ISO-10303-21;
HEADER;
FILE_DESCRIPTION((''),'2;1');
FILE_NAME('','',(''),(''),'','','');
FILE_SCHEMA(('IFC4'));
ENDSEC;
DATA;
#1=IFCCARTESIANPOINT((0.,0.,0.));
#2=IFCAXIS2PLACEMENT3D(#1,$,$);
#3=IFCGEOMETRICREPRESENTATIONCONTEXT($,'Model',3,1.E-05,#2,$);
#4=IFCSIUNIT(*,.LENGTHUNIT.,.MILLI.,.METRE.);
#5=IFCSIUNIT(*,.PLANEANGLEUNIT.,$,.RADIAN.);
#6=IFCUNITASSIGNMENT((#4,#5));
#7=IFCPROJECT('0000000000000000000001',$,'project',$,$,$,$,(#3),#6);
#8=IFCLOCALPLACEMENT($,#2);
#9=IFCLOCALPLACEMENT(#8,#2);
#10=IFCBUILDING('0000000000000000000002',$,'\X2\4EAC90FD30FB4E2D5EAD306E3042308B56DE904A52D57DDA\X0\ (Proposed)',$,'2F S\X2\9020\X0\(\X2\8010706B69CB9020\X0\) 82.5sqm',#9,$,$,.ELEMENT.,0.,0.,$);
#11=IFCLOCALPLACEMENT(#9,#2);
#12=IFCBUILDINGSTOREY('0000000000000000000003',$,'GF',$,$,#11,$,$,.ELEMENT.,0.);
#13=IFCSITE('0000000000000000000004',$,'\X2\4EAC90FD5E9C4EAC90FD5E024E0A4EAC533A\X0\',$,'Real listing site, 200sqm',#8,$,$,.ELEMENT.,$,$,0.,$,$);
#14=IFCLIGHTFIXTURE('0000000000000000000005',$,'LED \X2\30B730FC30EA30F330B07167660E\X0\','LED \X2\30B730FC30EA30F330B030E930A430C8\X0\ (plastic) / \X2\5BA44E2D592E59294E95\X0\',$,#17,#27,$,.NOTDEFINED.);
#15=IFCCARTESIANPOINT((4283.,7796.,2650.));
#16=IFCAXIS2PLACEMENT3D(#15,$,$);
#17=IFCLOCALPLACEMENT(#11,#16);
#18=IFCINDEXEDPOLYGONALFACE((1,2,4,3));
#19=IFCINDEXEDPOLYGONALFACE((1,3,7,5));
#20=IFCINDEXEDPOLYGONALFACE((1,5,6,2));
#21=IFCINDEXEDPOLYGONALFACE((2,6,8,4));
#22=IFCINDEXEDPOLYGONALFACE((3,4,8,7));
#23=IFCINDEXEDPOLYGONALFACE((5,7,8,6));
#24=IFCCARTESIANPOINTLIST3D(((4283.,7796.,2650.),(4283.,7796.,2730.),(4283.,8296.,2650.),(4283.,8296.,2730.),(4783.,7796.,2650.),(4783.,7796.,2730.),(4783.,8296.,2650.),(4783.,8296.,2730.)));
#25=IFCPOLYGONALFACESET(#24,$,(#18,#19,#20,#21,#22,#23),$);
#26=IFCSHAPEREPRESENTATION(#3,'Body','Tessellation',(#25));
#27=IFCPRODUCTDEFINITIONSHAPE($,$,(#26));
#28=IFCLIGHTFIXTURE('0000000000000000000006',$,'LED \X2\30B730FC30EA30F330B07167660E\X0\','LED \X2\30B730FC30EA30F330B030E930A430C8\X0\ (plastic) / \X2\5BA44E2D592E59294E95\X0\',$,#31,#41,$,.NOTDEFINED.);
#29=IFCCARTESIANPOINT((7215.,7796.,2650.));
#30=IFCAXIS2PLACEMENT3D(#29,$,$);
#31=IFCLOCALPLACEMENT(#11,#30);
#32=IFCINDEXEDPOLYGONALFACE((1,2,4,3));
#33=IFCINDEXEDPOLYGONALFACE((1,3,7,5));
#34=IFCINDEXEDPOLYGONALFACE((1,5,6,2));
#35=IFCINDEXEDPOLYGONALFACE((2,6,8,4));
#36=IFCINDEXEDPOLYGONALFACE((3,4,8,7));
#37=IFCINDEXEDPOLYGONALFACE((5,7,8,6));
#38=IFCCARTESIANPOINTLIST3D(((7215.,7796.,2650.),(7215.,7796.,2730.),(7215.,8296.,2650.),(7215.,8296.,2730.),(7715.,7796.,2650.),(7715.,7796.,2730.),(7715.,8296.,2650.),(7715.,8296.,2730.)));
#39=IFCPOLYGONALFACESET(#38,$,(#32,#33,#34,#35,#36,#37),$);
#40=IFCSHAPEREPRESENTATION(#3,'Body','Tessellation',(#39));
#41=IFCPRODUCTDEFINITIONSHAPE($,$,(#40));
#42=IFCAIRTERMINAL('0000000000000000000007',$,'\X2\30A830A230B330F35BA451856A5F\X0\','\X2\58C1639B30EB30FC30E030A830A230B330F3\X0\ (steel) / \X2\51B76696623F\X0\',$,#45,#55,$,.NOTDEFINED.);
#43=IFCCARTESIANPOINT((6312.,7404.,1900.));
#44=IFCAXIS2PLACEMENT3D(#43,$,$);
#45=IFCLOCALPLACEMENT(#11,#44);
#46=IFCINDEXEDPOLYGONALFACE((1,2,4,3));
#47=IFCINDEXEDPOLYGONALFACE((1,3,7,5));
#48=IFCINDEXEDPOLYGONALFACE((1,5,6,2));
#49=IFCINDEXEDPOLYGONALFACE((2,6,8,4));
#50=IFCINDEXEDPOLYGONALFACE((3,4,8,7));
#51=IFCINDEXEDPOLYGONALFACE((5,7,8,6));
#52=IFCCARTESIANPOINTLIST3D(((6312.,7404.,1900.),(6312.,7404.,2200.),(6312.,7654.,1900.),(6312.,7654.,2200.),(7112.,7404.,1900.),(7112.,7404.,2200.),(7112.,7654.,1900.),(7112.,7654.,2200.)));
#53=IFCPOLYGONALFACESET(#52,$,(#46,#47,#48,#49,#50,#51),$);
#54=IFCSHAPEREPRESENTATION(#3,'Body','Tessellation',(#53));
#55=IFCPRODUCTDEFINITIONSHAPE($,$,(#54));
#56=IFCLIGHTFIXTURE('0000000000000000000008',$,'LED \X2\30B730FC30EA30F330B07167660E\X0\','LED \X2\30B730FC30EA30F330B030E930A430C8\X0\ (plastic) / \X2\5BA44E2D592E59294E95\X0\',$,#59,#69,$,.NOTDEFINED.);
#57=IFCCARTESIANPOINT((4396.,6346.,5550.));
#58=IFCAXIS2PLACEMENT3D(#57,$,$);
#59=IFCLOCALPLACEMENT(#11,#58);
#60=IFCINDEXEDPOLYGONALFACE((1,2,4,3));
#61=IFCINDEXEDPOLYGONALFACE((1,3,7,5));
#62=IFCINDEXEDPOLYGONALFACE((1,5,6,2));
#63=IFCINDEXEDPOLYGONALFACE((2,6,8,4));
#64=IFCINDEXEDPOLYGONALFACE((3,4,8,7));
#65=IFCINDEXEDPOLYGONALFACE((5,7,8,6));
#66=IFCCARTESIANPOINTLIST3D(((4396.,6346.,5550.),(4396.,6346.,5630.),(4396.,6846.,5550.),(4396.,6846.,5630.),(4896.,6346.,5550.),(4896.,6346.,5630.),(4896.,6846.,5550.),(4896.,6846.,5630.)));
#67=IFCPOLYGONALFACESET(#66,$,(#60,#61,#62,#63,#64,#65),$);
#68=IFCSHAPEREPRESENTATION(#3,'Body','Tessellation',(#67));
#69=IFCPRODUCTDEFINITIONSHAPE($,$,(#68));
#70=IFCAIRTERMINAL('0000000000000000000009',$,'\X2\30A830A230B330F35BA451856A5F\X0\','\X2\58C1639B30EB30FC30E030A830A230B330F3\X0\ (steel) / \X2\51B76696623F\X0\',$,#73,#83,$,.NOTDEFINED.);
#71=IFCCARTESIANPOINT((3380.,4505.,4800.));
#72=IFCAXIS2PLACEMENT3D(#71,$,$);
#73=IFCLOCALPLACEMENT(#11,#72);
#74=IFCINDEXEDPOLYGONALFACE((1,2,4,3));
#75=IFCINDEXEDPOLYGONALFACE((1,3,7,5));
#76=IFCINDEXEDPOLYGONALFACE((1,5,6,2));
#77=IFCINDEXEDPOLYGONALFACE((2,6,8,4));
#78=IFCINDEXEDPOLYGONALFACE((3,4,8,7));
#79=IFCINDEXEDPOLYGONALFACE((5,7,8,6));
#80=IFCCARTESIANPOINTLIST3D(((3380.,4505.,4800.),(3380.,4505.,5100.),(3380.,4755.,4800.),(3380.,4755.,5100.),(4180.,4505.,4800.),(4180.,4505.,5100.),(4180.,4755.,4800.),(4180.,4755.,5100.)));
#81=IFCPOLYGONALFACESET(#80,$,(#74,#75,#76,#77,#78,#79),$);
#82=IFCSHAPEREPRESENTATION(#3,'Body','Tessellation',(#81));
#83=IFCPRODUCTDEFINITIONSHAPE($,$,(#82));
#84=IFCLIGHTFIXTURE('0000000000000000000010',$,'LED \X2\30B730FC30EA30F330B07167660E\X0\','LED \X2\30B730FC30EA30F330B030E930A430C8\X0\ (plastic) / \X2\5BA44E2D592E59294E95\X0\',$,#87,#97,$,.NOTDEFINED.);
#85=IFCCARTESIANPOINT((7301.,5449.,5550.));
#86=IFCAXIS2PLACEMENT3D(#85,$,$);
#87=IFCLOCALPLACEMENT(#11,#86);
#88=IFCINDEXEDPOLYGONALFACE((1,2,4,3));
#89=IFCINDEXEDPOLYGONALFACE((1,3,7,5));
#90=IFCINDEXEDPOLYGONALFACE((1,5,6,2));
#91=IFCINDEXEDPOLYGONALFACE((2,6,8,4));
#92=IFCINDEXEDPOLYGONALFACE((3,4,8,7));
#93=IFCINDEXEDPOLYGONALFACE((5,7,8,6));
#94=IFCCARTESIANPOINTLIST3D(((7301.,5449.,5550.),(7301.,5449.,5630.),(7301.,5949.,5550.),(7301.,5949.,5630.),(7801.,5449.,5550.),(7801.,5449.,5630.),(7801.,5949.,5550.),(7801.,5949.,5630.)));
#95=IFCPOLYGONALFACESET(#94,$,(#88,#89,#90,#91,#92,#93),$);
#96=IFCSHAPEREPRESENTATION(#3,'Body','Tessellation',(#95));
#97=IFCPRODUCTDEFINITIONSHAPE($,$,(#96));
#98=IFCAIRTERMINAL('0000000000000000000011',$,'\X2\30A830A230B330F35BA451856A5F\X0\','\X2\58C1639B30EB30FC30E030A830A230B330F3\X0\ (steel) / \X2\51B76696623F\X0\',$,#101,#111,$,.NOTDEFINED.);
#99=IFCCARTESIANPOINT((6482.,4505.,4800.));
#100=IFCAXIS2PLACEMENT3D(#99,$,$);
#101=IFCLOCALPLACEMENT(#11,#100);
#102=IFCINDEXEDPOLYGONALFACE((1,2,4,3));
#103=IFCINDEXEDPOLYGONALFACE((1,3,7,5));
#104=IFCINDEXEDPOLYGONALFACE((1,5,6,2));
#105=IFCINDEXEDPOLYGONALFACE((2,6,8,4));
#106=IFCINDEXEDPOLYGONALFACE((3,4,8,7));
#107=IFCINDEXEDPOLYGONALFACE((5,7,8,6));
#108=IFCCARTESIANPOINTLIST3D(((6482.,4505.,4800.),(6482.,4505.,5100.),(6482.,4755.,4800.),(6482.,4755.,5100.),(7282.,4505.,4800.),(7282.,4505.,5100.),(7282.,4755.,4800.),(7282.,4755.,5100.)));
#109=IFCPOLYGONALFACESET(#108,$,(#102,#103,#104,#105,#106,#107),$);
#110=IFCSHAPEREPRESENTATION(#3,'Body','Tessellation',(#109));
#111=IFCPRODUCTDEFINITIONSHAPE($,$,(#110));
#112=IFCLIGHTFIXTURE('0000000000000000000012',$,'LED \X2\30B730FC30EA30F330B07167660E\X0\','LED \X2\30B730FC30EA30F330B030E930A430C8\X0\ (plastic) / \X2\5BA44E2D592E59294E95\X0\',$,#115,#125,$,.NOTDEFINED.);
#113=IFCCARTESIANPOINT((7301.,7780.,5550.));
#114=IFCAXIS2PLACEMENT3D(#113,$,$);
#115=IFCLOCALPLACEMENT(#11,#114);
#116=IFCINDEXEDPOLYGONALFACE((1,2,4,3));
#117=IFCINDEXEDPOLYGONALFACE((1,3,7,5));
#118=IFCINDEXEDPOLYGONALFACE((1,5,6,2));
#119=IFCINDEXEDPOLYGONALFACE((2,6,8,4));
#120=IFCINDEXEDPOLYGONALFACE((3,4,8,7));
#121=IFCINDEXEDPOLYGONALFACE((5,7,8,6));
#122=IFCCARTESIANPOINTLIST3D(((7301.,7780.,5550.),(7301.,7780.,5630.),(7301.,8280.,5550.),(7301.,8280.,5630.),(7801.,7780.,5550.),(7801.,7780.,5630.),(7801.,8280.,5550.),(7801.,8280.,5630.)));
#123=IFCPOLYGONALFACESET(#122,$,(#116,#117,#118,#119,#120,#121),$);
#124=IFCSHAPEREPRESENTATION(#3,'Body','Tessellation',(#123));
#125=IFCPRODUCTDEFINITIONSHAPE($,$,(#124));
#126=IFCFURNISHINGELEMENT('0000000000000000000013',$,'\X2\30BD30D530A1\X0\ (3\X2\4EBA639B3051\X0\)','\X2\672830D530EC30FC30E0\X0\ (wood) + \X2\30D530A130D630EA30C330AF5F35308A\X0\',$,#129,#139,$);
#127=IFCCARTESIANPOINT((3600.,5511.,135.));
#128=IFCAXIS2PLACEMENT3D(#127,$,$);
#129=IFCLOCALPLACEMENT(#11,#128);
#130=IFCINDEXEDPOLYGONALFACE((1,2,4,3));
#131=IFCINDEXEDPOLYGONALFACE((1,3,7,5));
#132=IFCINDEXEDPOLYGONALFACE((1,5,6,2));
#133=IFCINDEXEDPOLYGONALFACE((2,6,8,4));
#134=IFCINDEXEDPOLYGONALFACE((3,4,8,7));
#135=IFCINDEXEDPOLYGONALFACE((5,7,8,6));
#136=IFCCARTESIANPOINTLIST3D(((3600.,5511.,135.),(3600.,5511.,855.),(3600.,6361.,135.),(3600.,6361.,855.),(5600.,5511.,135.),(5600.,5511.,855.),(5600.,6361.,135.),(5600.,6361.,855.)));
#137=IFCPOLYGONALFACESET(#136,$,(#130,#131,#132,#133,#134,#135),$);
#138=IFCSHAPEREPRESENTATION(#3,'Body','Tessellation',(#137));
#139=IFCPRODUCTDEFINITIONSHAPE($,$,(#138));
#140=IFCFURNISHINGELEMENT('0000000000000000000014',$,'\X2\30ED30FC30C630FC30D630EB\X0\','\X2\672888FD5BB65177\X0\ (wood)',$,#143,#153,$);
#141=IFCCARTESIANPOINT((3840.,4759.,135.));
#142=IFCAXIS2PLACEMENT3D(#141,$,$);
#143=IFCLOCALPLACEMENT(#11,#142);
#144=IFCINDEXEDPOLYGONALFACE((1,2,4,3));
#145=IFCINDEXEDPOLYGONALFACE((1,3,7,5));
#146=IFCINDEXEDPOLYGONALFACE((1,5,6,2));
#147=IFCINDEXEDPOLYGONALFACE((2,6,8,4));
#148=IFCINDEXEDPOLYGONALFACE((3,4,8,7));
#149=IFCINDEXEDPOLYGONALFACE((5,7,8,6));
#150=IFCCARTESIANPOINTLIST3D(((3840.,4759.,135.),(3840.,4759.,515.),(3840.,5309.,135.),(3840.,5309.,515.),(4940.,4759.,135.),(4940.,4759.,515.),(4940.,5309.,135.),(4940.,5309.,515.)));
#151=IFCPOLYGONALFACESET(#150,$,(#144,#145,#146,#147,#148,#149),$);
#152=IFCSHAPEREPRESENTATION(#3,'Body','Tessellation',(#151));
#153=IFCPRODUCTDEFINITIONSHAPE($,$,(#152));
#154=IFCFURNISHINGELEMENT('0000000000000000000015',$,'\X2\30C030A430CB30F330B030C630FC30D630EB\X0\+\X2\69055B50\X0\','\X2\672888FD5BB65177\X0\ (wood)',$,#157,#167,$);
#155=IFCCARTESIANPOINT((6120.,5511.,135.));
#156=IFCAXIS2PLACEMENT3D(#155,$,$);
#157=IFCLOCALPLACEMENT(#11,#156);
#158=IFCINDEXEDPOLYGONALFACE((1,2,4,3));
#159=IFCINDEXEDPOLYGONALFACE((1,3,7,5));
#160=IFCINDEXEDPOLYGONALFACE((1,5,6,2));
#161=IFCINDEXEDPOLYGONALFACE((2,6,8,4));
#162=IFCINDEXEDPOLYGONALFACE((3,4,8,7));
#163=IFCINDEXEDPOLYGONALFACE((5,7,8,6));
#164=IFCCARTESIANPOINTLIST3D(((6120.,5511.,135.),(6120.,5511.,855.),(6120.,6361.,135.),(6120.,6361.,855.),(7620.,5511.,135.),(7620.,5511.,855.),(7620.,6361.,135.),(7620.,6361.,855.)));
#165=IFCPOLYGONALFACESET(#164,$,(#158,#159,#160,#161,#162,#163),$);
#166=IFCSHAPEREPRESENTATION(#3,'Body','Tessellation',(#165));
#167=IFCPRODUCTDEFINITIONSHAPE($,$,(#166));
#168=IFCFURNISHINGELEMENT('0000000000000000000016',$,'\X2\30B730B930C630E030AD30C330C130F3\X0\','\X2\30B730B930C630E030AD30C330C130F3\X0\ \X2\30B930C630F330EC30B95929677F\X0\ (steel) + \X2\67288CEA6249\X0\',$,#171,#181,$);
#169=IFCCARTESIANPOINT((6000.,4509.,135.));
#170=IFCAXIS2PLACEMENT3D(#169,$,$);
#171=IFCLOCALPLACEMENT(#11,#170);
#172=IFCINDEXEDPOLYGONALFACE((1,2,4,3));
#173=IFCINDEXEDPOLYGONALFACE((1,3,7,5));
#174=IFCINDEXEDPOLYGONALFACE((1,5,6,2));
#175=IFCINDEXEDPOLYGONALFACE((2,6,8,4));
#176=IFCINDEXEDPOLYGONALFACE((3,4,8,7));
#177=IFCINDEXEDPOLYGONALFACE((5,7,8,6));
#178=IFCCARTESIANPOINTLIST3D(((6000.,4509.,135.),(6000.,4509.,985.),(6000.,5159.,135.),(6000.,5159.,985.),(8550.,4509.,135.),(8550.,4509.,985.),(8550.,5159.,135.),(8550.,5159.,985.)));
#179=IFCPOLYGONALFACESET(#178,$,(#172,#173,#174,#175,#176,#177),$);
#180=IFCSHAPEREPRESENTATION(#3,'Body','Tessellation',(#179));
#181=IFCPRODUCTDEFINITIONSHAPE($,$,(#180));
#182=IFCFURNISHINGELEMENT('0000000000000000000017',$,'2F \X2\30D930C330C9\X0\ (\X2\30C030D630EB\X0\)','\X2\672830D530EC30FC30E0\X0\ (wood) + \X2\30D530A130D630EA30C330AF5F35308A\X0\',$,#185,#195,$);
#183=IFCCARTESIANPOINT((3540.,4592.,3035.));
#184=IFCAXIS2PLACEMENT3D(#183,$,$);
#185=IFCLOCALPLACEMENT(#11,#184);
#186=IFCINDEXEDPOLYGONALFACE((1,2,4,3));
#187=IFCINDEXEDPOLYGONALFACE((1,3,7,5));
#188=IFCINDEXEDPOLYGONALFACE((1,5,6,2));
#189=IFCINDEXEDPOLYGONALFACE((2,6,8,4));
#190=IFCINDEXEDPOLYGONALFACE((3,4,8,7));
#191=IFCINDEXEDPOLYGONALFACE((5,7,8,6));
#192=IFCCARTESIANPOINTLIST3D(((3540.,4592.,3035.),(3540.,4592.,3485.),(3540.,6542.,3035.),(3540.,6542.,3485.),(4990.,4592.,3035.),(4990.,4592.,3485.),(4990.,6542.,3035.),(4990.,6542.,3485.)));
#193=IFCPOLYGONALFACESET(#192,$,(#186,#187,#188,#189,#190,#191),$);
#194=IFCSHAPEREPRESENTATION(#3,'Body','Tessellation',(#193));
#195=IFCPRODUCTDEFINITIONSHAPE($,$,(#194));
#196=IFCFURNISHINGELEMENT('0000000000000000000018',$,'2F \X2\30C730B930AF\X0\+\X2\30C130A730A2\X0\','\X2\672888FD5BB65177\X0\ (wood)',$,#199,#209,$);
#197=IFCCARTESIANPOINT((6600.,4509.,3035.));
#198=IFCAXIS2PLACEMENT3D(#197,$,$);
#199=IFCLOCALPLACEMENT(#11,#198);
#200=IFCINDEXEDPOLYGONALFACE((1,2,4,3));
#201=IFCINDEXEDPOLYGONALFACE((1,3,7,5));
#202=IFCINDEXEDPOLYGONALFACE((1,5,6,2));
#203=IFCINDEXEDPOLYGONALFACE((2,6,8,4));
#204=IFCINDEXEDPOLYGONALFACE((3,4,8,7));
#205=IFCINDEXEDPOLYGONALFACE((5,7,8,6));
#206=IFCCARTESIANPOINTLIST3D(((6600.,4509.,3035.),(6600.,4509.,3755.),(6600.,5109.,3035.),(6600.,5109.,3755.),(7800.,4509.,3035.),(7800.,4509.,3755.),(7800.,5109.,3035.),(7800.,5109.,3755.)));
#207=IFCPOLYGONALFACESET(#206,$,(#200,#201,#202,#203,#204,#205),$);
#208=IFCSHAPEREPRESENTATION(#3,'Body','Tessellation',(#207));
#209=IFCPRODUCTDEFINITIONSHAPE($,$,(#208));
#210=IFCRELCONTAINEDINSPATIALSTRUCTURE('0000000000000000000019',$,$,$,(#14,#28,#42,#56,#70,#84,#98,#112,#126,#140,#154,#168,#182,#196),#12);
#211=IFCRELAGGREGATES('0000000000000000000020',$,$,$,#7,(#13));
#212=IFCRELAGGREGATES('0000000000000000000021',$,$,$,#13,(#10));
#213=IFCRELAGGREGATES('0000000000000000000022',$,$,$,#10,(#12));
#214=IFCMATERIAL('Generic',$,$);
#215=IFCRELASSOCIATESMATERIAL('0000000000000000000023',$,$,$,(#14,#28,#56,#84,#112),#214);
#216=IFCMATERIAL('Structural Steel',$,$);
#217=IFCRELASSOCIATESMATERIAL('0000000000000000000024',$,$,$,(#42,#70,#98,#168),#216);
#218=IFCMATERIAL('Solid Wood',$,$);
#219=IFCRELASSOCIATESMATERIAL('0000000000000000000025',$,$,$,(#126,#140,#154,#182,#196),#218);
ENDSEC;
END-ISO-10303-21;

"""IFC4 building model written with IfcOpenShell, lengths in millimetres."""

from ifc_helpers import new_model, si_unit, frame, frame_2d, origin, place, context, project, spatial, rectangle, extrude, material, element, save


model = new_model("IFC4")

# Units and contexts
model_context = context("Model", 3, precision=1e-05, world=origin())
ifc_project = project(units=[si_unit("LENGTHUNIT", "METRE", prefix="MILLI"), si_unit("PLANEANGLEUNIT", "RADIAN")], contexts=[model_context])

# Site, building, storey
site_placement = place(None, origin())
site = spatial("IfcSite", under=ifc_project, at=site_placement, Name="京都府京都市上京区", ObjectType="Real listing site, 200sqm", CompositionType="ELEMENT", RefElevation=0.0)
building_placement = place(site_placement, origin())
building = spatial("IfcBuilding", under=site, at=building_placement, Name="京都・中庭のある回遊動線 (Proposed)", ObjectType="2F S造(耐火構造) 82.5sqm", CompositionType="ELEMENT", ElevationOfRefHeight=0.0, ElevationOfTerrain=0.0)
storey_placement = place(building_placement, origin())
storey = spatial("IfcBuildingStorey", under=building, at=storey_placement, Name="GF", CompositionType="ELEMENT", Elevation=0.0)

# Shared definitions
ifc_material_1 = material(Name="Solid Wood")

# Shared definitions
ifc_material_2 = material(Name="Structural Steel")

# Shared definitions
ifc_material_3 = material(Name="Generic")

# Light fixtures
light_fixture_1_placement = place(storey_placement, frame((4283.0, 7796.0, 2650.0)))
element("IfcLightFixture", 1, at=light_fixture_1_placement, inside=storey, material=ifc_material_3, Name="LED シーリング照明", Description="LED シーリングライト (plastic) / 室中央天井", PredefinedType="NOTDEFINED", context=model_context, shape_type="SweptSolid", body=[
    extrude(rectangle(XDim=500.0, YDim=500.0, at=frame_2d((250.0, 250.0))), frame((4283.0, 7796.0, 2650.0)), (0.0, 0.0, 1.0), 80.0),
])
light_fixture_2_placement = place(storey_placement, frame((7215.0, 7796.0, 2650.0)))
element("IfcLightFixture", 2, at=light_fixture_2_placement, inside=storey, material=ifc_material_3, Name="LED シーリング照明", Description="LED シーリングライト (plastic) / 室中央天井", PredefinedType="NOTDEFINED", context=model_context, shape_type="SweptSolid", body=[
    extrude(rectangle(XDim=500.0, YDim=500.0, at=frame_2d((250.0, 250.0))), frame((7215.0, 7796.0, 2650.0)), (0.0, 0.0, 1.0), 80.0),
])

# Air terminal
air_terminal_1_placement = place(storey_placement, frame((6312.0, 7404.0, 1900.0)))
element("IfcAirTerminal", 3, at=air_terminal_1_placement, inside=storey, material=ifc_material_2, Name="エアコン室内機", Description="壁掛ルームエアコン (steel) / 冷暖房", PredefinedType="NOTDEFINED", context=model_context, shape_type="SweptSolid", body=[
    extrude(rectangle(XDim=800.0, YDim=250.0, at=frame_2d((400.0, 125.0))), frame((6312.0, 7404.0, 1900.0)), (0.0, 0.0, 1.0), 300.0),
])

# Light fixture
light_fixture_3_placement = place(storey_placement, frame((4396.0, 6346.0, 5550.0)))
element("IfcLightFixture", 4, at=light_fixture_3_placement, inside=storey, material=ifc_material_3, Name="LED シーリング照明", Description="LED シーリングライト (plastic) / 室中央天井", PredefinedType="NOTDEFINED", context=model_context, shape_type="SweptSolid", body=[
    extrude(rectangle(XDim=500.0, YDim=500.0, at=frame_2d((250.0, 250.0))), frame((4396.0, 6346.0, 5550.0)), (0.0, 0.0, 1.0), 80.0),
])

# Air terminal
air_terminal_2_placement = place(storey_placement, frame((3380.0, 4505.0, 4800.0)))
element("IfcAirTerminal", 5, at=air_terminal_2_placement, inside=storey, material=ifc_material_2, Name="エアコン室内機", Description="壁掛ルームエアコン (steel) / 冷暖房", PredefinedType="NOTDEFINED", context=model_context, shape_type="SweptSolid", body=[
    extrude(rectangle(XDim=800.0, YDim=250.0, at=frame_2d((400.0, 125.0))), frame((3380.0, 4505.0, 4800.0)), (0.0, 0.0, 1.0), 300.0),
])

# Light fixture
light_fixture_4_placement = place(storey_placement, frame((7301.0, 5449.0, 5550.0)))
element("IfcLightFixture", 6, at=light_fixture_4_placement, inside=storey, material=ifc_material_3, Name="LED シーリング照明", Description="LED シーリングライト (plastic) / 室中央天井", PredefinedType="NOTDEFINED", context=model_context, shape_type="SweptSolid", body=[
    extrude(rectangle(XDim=500.0, YDim=500.0, at=frame_2d((250.0, 250.0))), frame((7301.0, 5449.0, 5550.0)), (0.0, 0.0, 1.0), 80.0),
])

# Air terminal
air_terminal_3_placement = place(storey_placement, frame((6482.0, 4505.0, 4800.0)))
element("IfcAirTerminal", 7, at=air_terminal_3_placement, inside=storey, material=ifc_material_2, Name="エアコン室内機", Description="壁掛ルームエアコン (steel) / 冷暖房", PredefinedType="NOTDEFINED", context=model_context, shape_type="SweptSolid", body=[
    extrude(rectangle(XDim=800.0, YDim=250.0, at=frame_2d((400.0, 125.0))), frame((6482.0, 4505.0, 4800.0)), (0.0, 0.0, 1.0), 300.0),
])

# Light fixture
light_fixture_5_placement = place(storey_placement, frame((7301.0, 7780.0, 5550.0)))
element("IfcLightFixture", 8, at=light_fixture_5_placement, inside=storey, material=ifc_material_3, Name="LED シーリング照明", Description="LED シーリングライト (plastic) / 室中央天井", PredefinedType="NOTDEFINED", context=model_context, shape_type="SweptSolid", body=[
    extrude(rectangle(XDim=500.0, YDim=500.0, at=frame_2d((250.0, 250.0))), frame((7301.0, 7780.0, 5550.0)), (0.0, 0.0, 1.0), 80.0),
])

# Furnishing elements
furnishing_1_placement = place(storey_placement, frame((3600.0, 5511.0, 135.0)))
element("IfcFurnishingElement", 9, at=furnishing_1_placement, inside=storey, material=ifc_material_1, Name="ソファ (3人掛け)", Description="木フレーム (wood) + ファブリック張り", context=model_context, shape_type="SweptSolid", body=[
    extrude(rectangle(XDim=2000.0, YDim=850.0, at=frame_2d((1000.0, 425.0))), frame((3600.0, 5511.0, 135.0)), (0.0, 0.0, 1.0), 720.0),
])
furnishing_2_placement = place(storey_placement, frame((3840.0, 4759.0, 135.0)))
element("IfcFurnishingElement", 10, at=furnishing_2_placement, inside=storey, material=ifc_material_1, Name="ローテーブル", Description="木製家具 (wood)", context=model_context, shape_type="SweptSolid", body=[
    extrude(rectangle(XDim=1100.0, YDim=550.0, at=frame_2d((550.0, 275.0))), frame((3840.0, 4759.0, 135.0)), (0.0, 0.0, 1.0), 380.0),
])
furnishing_3_placement = place(storey_placement, frame((6120.0, 5511.0, 135.0)))
element("IfcFurnishingElement", 11, at=furnishing_3_placement, inside=storey, material=ifc_material_1, Name="ダイニングテーブル+椅子", Description="木製家具 (wood)", context=model_context, shape_type="SweptSolid", body=[
    extrude(rectangle(XDim=1500.0, YDim=850.0, at=frame_2d((750.0, 425.0))), frame((6120.0, 5511.0, 135.0)), (0.0, 0.0, 1.0), 720.0),
])
furnishing_4_placement = place(storey_placement, frame((6000.0, 4509.0, 135.0)))
element("IfcFurnishingElement", 12, at=furnishing_4_placement, inside=storey, material=ifc_material_2, Name="システムキッチン", Description="システムキッチン ステンレス天板 (steel) + 木質扉", context=model_context, shape_type="SweptSolid", body=[
    extrude(rectangle(XDim=2550.0, YDim=650.0, at=frame_2d((1275.0, 325.0))), frame((6000.0, 4509.0, 135.0)), (0.0, 0.0, 1.0), 850.0),
])
furnishing_5_placement = place(storey_placement, frame((3540.0, 4592.0, 3035.0)))
element("IfcFurnishingElement", 13, at=furnishing_5_placement, inside=storey, material=ifc_material_1, Name="2F ベッド (ダブル)", Description="木フレーム (wood) + ファブリック張り", context=model_context, shape_type="SweptSolid", body=[
    extrude(rectangle(XDim=1450.0, YDim=1950.0, at=frame_2d((725.0, 975.0))), frame((3540.0, 4592.0, 3035.0)), (0.0, 0.0, 1.0), 450.0),
])
furnishing_6_placement = place(storey_placement, frame((6600.0, 4509.0, 3035.0)))
element("IfcFurnishingElement", 14, at=furnishing_6_placement, inside=storey, material=ifc_material_1, Name="2F デスク+チェア", Description="木製家具 (wood)", context=model_context, shape_type="SweptSolid", body=[
    extrude(rectangle(XDim=1200.0, YDim=600.0, at=frame_2d((600.0, 300.0))), frame((6600.0, 4509.0, 3035.0)), (0.0, 0.0, 1.0), 720.0),
])

save(model, "model.ifc")
